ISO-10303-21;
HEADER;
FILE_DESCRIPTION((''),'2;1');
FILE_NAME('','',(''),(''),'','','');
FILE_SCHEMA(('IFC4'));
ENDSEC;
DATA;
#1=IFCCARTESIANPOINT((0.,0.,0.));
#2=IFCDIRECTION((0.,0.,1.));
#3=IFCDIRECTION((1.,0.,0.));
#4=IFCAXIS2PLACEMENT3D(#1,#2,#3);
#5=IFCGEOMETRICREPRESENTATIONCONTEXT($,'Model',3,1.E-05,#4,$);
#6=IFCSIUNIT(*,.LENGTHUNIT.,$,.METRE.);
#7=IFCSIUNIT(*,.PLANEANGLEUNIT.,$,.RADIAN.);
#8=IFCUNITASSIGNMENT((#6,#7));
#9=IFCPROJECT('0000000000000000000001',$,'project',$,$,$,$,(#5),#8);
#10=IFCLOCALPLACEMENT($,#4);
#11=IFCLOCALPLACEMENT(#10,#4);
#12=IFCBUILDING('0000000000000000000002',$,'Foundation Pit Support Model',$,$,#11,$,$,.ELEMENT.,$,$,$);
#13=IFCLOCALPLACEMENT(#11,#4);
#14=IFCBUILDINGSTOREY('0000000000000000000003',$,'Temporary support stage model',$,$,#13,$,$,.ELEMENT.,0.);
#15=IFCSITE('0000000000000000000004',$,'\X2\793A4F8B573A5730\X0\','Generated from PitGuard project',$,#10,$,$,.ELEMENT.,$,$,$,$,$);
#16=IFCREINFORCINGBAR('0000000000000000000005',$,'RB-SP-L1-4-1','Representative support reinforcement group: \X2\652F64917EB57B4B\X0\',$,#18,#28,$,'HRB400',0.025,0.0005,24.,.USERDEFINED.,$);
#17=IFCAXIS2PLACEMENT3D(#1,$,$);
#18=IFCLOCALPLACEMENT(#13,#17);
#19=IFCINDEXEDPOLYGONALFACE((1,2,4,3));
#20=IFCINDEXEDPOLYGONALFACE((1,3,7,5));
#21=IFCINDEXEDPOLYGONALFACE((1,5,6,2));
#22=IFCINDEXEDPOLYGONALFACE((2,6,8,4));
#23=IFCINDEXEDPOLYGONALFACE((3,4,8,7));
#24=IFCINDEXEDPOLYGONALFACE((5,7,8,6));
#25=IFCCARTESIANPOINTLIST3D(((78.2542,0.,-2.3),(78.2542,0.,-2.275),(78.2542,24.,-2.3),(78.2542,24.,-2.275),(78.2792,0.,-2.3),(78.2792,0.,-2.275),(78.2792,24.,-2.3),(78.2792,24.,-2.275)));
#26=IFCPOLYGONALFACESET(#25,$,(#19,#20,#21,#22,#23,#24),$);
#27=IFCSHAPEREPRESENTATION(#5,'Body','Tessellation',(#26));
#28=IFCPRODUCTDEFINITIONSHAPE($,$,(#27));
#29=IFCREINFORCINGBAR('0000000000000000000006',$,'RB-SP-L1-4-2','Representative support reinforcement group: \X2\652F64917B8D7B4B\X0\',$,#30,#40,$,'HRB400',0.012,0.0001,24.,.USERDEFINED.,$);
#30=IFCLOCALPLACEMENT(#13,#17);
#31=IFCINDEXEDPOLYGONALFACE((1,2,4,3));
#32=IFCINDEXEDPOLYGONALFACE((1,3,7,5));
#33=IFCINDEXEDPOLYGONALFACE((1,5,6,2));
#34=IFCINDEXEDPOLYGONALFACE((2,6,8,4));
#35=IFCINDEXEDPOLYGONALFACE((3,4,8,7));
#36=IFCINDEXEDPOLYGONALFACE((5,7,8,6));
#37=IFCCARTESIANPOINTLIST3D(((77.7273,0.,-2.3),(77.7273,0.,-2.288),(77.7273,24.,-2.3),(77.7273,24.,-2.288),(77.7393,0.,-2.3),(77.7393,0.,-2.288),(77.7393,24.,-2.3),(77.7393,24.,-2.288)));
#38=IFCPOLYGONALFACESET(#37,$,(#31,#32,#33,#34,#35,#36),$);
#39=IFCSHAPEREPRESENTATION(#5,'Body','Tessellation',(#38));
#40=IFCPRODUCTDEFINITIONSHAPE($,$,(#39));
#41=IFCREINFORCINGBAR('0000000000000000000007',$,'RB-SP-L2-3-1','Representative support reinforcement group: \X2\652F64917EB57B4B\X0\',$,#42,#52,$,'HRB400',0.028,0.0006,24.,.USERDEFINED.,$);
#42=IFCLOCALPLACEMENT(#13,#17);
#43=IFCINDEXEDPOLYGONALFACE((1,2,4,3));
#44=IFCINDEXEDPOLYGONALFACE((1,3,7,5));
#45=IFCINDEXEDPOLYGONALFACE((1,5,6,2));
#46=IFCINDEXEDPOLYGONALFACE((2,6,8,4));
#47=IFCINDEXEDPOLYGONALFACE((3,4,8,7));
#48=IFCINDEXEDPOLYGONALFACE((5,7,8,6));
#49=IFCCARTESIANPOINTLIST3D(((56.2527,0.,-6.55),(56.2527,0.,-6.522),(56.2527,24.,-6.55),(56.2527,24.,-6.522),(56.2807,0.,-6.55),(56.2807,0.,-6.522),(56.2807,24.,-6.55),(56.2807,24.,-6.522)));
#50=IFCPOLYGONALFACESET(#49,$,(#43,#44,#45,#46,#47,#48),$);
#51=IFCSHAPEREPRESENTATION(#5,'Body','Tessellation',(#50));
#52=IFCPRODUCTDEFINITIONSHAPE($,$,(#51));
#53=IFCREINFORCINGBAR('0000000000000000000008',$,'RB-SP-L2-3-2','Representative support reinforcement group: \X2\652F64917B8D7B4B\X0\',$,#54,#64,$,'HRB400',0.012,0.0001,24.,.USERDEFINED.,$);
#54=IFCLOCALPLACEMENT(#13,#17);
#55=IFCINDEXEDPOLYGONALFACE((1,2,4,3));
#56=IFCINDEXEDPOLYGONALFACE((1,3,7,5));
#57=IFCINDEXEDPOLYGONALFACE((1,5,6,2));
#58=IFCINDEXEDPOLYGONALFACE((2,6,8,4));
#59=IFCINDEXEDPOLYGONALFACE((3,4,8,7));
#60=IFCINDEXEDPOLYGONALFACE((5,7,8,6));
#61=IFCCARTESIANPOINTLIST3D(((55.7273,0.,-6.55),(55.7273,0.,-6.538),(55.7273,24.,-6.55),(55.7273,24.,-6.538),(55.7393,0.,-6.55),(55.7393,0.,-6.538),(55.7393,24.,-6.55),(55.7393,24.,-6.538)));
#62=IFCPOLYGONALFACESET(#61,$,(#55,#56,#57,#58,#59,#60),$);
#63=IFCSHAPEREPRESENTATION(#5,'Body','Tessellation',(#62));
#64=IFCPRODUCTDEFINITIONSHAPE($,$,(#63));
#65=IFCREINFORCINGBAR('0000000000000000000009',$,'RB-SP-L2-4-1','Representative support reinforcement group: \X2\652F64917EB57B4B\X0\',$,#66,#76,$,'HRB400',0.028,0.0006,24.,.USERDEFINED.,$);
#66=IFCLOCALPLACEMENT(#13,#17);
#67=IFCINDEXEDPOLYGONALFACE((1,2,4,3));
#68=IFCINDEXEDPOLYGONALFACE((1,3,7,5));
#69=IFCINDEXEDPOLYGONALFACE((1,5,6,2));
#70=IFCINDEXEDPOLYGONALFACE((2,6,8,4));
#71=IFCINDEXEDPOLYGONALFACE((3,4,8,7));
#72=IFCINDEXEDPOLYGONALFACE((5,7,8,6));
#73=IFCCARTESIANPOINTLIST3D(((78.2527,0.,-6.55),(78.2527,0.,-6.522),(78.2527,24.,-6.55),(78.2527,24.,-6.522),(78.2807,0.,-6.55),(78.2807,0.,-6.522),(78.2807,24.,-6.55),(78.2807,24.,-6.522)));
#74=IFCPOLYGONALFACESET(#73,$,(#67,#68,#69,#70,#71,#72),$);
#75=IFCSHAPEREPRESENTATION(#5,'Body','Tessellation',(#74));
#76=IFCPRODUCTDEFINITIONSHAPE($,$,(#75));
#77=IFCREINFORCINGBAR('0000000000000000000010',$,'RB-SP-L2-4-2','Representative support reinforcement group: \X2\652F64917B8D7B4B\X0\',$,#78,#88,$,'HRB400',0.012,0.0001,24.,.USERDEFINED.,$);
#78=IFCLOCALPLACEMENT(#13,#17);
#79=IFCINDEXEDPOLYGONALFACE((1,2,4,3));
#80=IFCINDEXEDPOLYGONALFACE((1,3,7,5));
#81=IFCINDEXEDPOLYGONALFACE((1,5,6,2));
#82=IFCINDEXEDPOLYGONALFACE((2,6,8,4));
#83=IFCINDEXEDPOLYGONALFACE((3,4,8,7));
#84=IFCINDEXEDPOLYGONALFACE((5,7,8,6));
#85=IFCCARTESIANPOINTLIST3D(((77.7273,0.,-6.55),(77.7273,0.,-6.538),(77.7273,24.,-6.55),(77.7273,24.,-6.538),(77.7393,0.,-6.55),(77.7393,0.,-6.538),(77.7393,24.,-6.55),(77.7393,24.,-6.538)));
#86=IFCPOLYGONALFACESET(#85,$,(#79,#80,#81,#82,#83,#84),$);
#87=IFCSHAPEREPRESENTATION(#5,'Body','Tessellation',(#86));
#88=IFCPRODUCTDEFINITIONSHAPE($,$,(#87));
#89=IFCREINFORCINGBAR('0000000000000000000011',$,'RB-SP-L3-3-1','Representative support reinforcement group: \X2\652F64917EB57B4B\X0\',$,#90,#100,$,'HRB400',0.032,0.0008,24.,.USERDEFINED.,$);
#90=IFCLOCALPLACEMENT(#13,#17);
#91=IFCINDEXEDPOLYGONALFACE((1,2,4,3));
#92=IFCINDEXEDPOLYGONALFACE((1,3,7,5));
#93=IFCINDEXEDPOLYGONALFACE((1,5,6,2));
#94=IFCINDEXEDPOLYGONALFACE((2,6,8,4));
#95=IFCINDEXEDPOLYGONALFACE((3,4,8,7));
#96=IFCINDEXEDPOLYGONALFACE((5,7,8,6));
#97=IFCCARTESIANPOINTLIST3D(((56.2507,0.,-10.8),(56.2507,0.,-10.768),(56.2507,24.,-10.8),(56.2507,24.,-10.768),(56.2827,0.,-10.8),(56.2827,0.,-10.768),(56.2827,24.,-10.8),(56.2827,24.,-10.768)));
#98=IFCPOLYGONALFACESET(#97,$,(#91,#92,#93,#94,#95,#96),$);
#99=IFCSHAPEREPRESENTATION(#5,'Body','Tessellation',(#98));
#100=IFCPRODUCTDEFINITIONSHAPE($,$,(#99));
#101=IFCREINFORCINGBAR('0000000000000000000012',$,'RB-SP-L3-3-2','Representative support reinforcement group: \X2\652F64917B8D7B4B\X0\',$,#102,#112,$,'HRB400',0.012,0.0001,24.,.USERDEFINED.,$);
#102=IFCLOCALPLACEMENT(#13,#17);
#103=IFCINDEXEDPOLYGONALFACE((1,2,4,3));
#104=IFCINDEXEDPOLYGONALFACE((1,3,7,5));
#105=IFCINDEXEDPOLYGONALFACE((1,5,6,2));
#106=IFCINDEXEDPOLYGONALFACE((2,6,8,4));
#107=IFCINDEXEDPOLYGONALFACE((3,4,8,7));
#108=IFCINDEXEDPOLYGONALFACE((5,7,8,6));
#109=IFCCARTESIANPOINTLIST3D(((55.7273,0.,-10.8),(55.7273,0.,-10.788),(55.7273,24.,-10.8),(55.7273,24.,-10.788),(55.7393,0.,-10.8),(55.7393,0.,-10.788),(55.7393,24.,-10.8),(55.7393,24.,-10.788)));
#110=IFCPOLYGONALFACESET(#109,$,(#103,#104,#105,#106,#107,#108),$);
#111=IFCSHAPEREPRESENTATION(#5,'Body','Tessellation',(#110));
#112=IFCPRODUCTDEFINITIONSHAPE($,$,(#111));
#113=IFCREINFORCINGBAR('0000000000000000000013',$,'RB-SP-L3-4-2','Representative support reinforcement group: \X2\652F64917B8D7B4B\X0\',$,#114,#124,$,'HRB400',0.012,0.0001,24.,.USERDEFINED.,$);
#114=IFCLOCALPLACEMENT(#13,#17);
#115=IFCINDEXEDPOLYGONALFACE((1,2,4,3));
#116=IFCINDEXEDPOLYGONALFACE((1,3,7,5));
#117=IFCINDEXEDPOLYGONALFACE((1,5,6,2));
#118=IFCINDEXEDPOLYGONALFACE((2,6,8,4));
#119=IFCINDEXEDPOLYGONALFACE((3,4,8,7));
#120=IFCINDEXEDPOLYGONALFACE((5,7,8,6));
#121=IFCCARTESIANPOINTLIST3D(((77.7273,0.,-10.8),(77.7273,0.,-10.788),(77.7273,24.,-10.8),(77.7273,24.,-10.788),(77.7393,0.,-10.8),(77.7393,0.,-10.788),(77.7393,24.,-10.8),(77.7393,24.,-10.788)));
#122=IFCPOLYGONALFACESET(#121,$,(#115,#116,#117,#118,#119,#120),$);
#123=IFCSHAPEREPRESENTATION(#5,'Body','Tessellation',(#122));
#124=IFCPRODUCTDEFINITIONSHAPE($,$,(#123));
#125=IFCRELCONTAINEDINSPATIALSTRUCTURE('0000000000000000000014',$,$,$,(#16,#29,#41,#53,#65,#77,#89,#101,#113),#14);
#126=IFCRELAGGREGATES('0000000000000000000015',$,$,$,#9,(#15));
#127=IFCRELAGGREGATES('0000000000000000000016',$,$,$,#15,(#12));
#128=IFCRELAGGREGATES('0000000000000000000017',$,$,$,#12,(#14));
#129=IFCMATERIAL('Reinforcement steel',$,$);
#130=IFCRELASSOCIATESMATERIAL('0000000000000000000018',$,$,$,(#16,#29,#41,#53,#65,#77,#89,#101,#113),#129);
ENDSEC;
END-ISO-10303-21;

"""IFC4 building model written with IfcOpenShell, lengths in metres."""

from ifc_helpers import new_model, si_unit, frame, origin_with_axes, origin_2d, place, context, project, spatial, rectangle, extrude, material, element, save


model = new_model("IFC4")

# Units and contexts
model_context = context("Model", 3, precision=1e-05, world=origin_with_axes())
ifc_project = project(units=[si_unit("LENGTHUNIT", "METRE"), si_unit("PLANEANGLEUNIT", "RADIAN")], contexts=[model_context])

# Site, building, storey
site_placement = place(None, origin_with_axes())
site = spatial("IfcSite", under=ifc_project, at=site_placement, Name="示例场地", Description="Generated from PitGuard project", CompositionType="ELEMENT")
building_placement = place(site_placement, origin_with_axes())
building = spatial("IfcBuilding", under=site, at=building_placement, Name="Foundation Pit Support Model", CompositionType="ELEMENT")
storey_placement = place(building_placement, origin_with_axes())
storey = spatial("IfcBuildingStorey", under=building, at=storey_placement, Name="Temporary support stage model", CompositionType="ELEMENT", Elevation=0.0)

# Reinforcing bars
ifc_material_1 = material(Name="Reinforcement steel")
reinforcing_bar_1_placement = place(storey_placement, frame((78.2667, 12.0, -2.3), z_axis=(0.0, 0.0, 1.0), x_axis=(0.0, 1.0, 0.0)))
element("IfcReinforcingBar", 1, at=reinforcing_bar_1_placement, inside=storey, material=ifc_material_1, Name="RB-SP-L1-4-1", Description="Representative support reinforcement group: 支撑纵筋", SteelGrade="HRB400", BarLength=24.0, CrossSectionArea=0.0005, NominalDiameter=0.025, PredefinedType="USERDEFINED", context=model_context, shape_type="SweptSolid", body=[
    extrude(rectangle(XDim=24.0, YDim=0.025, at=origin_2d()), origin_with_axes(), (0.0, 0.0, 1.0), 0.025),
])
reinforcing_bar_2_placement = place(storey_placement, frame((77.7333, 12.0, -2.3), z_axis=(0.0, 0.0, 1.0), x_axis=(0.0, 1.0, 0.0)))
element("IfcReinforcingBar", 2, at=reinforcing_bar_2_placement, inside=storey, material=ifc_material_1, Name="RB-SP-L1-4-2", Description="Representative support reinforcement group: 支撑箍筋", SteelGrade="HRB400", BarLength=24.0, CrossSectionArea=0.0001, NominalDiameter=0.012, PredefinedType="USERDEFINED", context=model_context, shape_type="SweptSolid", body=[
    extrude(rectangle(XDim=24.0, YDim=0.012, at=origin_2d()), origin_with_axes(), (0.0, 0.0, 1.0), 0.012),
])
reinforcing_bar_3_placement = place(storey_placement, frame((56.2667, 12.0, -6.55), z_axis=(0.0, 0.0, 1.0), x_axis=(0.0, 1.0, 0.0)))
element("IfcReinforcingBar", 3, at=reinforcing_bar_3_placement, inside=storey, material=ifc_material_1, Name="RB-SP-L2-3-1", Description="Representative support reinforcement group: 支撑纵筋", SteelGrade="HRB400", BarLength=24.0, CrossSectionArea=0.0006, NominalDiameter=0.028, PredefinedType="USERDEFINED", context=model_context, shape_type="SweptSolid", body=[
    extrude(rectangle(XDim=24.0, YDim=0.028, at=origin_2d()), origin_with_axes(), (0.0, 0.0, 1.0), 0.028),
])
reinforcing_bar_4_placement = place(storey_placement, frame((55.7333, 12.0, -6.55), z_axis=(0.0, 0.0, 1.0), x_axis=(0.0, 1.0, 0.0)))
element("IfcReinforcingBar", 4, at=reinforcing_bar_4_placement, inside=storey, material=ifc_material_1, Name="RB-SP-L2-3-2", Description="Representative support reinforcement group: 支撑箍筋", SteelGrade="HRB400", BarLength=24.0, CrossSectionArea=0.0001, NominalDiameter=0.012, PredefinedType="USERDEFINED", context=model_context, shape_type="SweptSolid", body=[
    extrude(rectangle(XDim=24.0, YDim=0.012, at=origin_2d()), origin_with_axes(), (0.0, 0.0, 1.0), 0.012),
])
reinforcing_bar_5_placement = place(storey_placement, frame((78.2667, 12.0, -6.55), z_axis=(0.0, 0.0, 1.0), x_axis=(0.0, 1.0, 0.0)))
element("IfcReinforcingBar", 5, at=reinforcing_bar_5_placement, inside=storey, material=ifc_material_1, Name="RB-SP-L2-4-1", Description="Representative support reinforcement group: 支撑纵筋", SteelGrade="HRB400", BarLength=24.0, CrossSectionArea=0.0006, NominalDiameter=0.028, PredefinedType="USERDEFINED", context=model_context, shape_type="SweptSolid", body=[
    extrude(rectangle(XDim=24.0, YDim=0.028, at=origin_2d()), origin_with_axes(), (0.0, 0.0, 1.0), 0.028),
])
reinforcing_bar_6_placement = place(storey_placement, frame((77.7333, 12.0, -6.55), z_axis=(0.0, 0.0, 1.0), x_axis=(0.0, 1.0, 0.0)))
element("IfcReinforcingBar", 6, at=reinforcing_bar_6_placement, inside=storey, material=ifc_material_1, Name="RB-SP-L2-4-2", Description="Representative support reinforcement group: 支撑箍筋", SteelGrade="HRB400", BarLength=24.0, CrossSectionArea=0.0001, NominalDiameter=0.012, PredefinedType="USERDEFINED", context=model_context, shape_type="SweptSolid", body=[
    extrude(rectangle(XDim=24.0, YDim=0.012, at=origin_2d()), origin_with_axes(), (0.0, 0.0, 1.0), 0.012),
])
reinforcing_bar_7_placement = place(storey_placement, frame((56.2667, 12.0, -10.8), z_axis=(0.0, 0.0, 1.0), x_axis=(0.0, 1.0, 0.0)))
element("IfcReinforcingBar", 7, at=reinforcing_bar_7_placement, inside=storey, material=ifc_material_1, Name="RB-SP-L3-3-1", Description="Representative support reinforcement group: 支撑纵筋", SteelGrade="HRB400", BarLength=24.0, CrossSectionArea=0.0008, NominalDiameter=0.032, PredefinedType="USERDEFINED", context=model_context, shape_type="SweptSolid", body=[
    extrude(rectangle(XDim=24.0, YDim=0.032, at=origin_2d()), origin_with_axes(), (0.0, 0.0, 1.0), 0.032),
])
for number, where, z_axis, x_axis, name in (
    (8, (55.7333, 12.0, -10.8), (0.0, 0.0, 1.0), (0.0, 1.0, 0.0), "RB-SP-L3-3-2"),
    (9, (77.7333, 12.0, -10.8), (0.0, 0.0, 1.0), (0.0, 1.0, 0.0), "RB-SP-L3-4-2"),
):
    element("IfcReinforcingBar", number, at=place(storey_placement, frame(where, z_axis=z_axis, x_axis=x_axis)), inside=storey, material=ifc_material_1, Name=name, Description="Representative support reinforcement group: 支撑箍筋", SteelGrade="HRB400", BarLength=24.0, CrossSectionArea=0.0001, NominalDiameter=0.012, PredefinedType="USERDEFINED", context=model_context, shape_type="SweptSolid", body=[
        extrude(rectangle(XDim=24.0, YDim=0.012, at=origin_2d()), origin_with_axes(), (0.0, 0.0, 1.0), 0.012),
    ])

save(model, "model.ifc")
